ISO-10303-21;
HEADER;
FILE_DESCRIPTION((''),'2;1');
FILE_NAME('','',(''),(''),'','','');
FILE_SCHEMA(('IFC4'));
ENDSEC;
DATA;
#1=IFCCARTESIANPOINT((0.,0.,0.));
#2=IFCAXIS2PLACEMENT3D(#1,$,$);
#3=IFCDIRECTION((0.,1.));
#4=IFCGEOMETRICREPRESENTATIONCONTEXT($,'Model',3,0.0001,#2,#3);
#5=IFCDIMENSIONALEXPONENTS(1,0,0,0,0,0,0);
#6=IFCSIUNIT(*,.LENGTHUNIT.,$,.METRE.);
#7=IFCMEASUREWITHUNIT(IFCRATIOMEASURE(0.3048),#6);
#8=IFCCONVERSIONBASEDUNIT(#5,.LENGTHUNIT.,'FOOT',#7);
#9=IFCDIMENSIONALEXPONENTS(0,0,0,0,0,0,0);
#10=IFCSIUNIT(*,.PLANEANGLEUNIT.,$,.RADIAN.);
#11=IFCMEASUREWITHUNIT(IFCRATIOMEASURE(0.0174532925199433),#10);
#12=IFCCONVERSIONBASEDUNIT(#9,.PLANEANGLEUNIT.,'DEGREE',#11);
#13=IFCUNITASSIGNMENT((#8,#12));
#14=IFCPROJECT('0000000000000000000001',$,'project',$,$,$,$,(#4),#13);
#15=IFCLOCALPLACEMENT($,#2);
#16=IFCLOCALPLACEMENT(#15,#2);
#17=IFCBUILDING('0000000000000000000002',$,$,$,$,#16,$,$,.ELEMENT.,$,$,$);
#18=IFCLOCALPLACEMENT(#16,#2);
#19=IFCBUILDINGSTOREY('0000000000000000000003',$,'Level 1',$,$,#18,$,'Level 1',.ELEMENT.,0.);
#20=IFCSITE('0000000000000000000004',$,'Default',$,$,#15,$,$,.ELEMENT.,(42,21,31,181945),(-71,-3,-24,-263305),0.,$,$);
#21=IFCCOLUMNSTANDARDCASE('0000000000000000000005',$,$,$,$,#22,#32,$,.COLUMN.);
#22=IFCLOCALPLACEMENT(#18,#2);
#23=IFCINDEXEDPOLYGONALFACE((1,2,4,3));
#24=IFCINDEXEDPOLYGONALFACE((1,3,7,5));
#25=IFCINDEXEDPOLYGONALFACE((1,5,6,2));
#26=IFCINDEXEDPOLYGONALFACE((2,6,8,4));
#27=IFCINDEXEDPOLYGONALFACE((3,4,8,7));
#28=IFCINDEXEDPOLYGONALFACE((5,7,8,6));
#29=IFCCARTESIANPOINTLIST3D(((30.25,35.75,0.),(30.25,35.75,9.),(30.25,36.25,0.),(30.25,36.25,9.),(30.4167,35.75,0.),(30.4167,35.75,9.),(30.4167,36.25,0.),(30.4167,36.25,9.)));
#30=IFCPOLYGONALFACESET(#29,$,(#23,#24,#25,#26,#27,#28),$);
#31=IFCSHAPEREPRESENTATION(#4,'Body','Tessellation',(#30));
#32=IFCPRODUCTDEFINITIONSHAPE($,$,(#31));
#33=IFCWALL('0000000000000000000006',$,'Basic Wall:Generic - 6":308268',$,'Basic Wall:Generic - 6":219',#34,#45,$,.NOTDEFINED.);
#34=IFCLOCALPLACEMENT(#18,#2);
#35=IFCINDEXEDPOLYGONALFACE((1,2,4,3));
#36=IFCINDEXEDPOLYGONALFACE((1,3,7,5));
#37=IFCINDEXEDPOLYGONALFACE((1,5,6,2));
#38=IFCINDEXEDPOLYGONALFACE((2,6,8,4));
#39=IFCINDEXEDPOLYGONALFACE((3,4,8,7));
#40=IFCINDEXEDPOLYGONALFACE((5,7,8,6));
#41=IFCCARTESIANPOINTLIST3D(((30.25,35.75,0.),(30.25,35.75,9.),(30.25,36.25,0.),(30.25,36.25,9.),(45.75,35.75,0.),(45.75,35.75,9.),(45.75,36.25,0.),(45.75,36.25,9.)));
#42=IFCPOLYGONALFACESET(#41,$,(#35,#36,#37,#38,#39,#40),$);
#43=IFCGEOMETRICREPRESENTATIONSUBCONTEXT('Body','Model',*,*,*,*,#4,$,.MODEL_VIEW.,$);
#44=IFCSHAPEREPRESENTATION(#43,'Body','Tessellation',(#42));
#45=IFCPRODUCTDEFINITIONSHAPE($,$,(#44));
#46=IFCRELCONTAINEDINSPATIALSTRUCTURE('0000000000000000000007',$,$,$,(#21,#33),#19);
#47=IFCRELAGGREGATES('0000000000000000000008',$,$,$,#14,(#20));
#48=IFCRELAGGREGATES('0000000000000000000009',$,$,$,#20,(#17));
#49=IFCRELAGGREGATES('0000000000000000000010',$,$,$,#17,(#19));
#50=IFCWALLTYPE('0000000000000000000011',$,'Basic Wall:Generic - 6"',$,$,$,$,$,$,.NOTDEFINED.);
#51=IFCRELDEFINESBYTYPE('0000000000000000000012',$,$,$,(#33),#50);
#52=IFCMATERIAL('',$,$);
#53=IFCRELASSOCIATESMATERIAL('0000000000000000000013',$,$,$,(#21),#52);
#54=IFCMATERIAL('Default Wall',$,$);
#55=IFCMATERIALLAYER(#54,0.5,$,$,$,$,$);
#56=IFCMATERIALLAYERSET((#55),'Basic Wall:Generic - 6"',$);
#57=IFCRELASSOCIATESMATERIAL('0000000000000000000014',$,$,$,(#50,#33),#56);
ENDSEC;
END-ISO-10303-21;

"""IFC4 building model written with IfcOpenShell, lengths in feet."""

from ifc_helpers import new_model, entity, si_unit, converted_unit, direction, frame, frame_2d, origin, place, context, subcontext, project, spatial, polyline, rectangle, extrude, clip, bounded_halfspace, material, layer, layer_set, layer_usage, type_object, element, save


model = new_model("IFC4")

# Units and contexts
model_context = context("Model", 3, precision=0.0001, world=origin(), true_north=direction((0.0, 1.0)))
body_context = subcontext(model_context, "Body", "Model", "MODEL_VIEW")
ifc_project = project(units=[converted_unit("LENGTHUNIT", "FOOT", entity("IfcRatioMeasure", 0.3048), si_unit("LENGTHUNIT", "METRE"), dimensions=[1, 0, 0, 0, 0, 0, 0]), converted_unit("PLANEANGLEUNIT", "DEGREE", entity("IfcRatioMeasure", 0.0174532925199433), si_unit("PLANEANGLEUNIT", "RADIAN"), dimensions=[0, 0, 0, 0, 0, 0, 0])], contexts=[model_context])

# Site, building, storey
site_placement = place(None, origin())
site = spatial("IfcSite", under=ifc_project, at=site_placement, Name="Default", CompositionType="ELEMENT", RefLatitude=(42, 21, 31, 181945), RefLongitude=(-71, -3, -24, -263305), RefElevation=0.0)
building_placement = place(site_placement, origin())
building = spatial("IfcBuilding", under=site, at=building_placement, CompositionType="ELEMENT")
storey_placement = place(building_placement, origin())
storey = spatial("IfcBuildingStorey", under=building, at=storey_placement, Name="Level 1", LongName="Level 1", CompositionType="ELEMENT", Elevation=0.0)

# Column
ifc_material_1 = material(Name="")
wall_placement = place(storey_placement, frame((30.25, 36.0, 0.0)))
for number, where, z_axis, x_axis in (
    (1, (0.0833, 0.0, 0.0), (0.0, 0.0, 1.0), (1.0, 0.0, 0.0)),
):
    element("IfcColumnStandardCase", number, at=place(wall_placement, frame(where, z_axis=z_axis, x_axis=x_axis)), inside=storey, material=ifc_material_1, PredefinedType="COLUMN", context=model_context, shape_type="SweptSolid", body=[
        extrude(rectangle(XDim=0.1667, YDim=0.5), origin(), (0.0, 0.0, 1.0), 9.0),
    ])

# Wall
ifc_material_2 = material(Name="Default Wall")
ifc_layer = layer(ifc_material_2, 0.5)
ifc_layer_set = layer_set([ifc_layer], Name="Basic Wall:Generic - 6\"")
ifc_layer_usage = layer_usage(ifc_layer_set, "AXIS2", "NEGATIVE", 0.25)
wall_type = type_object("IfcWallType", Name="Basic Wall:Generic - 6\"", PredefinedType="NOTDEFINED", material=ifc_layer_set)
element("IfcWall", 2, at=wall_placement, inside=storey, type_object=wall_type, material=ifc_layer_usage, Name="Basic Wall:Generic - 6\":308268", ObjectType="Basic Wall:Generic - 6\":219", PredefinedType="NOTDEFINED", context=body_context, shape_type="Clipping", body=[
    clip(extrude(rectangle(XDim=15.5, YDim=0.5, at=frame_2d((7.75, 0.0), x_axis=(-1.0, 0.0))), origin(), (0.0, 0.0, 1.0), 9.0), bounded_halfspace(frame((0.0, -0.25, 9.0), z_axis=(0.0, 0.0, -1.0), x_axis=(1.0, 0.0, 0.0)), True, frame((0.0, -0.25, 9.0)), polyline([(0.0, 0.0), (15.5, 0.0), (15.5, 0.5), (0.0, 0.5), (0.0, 0.0)]))),
])

save(model, "model.ifc")
